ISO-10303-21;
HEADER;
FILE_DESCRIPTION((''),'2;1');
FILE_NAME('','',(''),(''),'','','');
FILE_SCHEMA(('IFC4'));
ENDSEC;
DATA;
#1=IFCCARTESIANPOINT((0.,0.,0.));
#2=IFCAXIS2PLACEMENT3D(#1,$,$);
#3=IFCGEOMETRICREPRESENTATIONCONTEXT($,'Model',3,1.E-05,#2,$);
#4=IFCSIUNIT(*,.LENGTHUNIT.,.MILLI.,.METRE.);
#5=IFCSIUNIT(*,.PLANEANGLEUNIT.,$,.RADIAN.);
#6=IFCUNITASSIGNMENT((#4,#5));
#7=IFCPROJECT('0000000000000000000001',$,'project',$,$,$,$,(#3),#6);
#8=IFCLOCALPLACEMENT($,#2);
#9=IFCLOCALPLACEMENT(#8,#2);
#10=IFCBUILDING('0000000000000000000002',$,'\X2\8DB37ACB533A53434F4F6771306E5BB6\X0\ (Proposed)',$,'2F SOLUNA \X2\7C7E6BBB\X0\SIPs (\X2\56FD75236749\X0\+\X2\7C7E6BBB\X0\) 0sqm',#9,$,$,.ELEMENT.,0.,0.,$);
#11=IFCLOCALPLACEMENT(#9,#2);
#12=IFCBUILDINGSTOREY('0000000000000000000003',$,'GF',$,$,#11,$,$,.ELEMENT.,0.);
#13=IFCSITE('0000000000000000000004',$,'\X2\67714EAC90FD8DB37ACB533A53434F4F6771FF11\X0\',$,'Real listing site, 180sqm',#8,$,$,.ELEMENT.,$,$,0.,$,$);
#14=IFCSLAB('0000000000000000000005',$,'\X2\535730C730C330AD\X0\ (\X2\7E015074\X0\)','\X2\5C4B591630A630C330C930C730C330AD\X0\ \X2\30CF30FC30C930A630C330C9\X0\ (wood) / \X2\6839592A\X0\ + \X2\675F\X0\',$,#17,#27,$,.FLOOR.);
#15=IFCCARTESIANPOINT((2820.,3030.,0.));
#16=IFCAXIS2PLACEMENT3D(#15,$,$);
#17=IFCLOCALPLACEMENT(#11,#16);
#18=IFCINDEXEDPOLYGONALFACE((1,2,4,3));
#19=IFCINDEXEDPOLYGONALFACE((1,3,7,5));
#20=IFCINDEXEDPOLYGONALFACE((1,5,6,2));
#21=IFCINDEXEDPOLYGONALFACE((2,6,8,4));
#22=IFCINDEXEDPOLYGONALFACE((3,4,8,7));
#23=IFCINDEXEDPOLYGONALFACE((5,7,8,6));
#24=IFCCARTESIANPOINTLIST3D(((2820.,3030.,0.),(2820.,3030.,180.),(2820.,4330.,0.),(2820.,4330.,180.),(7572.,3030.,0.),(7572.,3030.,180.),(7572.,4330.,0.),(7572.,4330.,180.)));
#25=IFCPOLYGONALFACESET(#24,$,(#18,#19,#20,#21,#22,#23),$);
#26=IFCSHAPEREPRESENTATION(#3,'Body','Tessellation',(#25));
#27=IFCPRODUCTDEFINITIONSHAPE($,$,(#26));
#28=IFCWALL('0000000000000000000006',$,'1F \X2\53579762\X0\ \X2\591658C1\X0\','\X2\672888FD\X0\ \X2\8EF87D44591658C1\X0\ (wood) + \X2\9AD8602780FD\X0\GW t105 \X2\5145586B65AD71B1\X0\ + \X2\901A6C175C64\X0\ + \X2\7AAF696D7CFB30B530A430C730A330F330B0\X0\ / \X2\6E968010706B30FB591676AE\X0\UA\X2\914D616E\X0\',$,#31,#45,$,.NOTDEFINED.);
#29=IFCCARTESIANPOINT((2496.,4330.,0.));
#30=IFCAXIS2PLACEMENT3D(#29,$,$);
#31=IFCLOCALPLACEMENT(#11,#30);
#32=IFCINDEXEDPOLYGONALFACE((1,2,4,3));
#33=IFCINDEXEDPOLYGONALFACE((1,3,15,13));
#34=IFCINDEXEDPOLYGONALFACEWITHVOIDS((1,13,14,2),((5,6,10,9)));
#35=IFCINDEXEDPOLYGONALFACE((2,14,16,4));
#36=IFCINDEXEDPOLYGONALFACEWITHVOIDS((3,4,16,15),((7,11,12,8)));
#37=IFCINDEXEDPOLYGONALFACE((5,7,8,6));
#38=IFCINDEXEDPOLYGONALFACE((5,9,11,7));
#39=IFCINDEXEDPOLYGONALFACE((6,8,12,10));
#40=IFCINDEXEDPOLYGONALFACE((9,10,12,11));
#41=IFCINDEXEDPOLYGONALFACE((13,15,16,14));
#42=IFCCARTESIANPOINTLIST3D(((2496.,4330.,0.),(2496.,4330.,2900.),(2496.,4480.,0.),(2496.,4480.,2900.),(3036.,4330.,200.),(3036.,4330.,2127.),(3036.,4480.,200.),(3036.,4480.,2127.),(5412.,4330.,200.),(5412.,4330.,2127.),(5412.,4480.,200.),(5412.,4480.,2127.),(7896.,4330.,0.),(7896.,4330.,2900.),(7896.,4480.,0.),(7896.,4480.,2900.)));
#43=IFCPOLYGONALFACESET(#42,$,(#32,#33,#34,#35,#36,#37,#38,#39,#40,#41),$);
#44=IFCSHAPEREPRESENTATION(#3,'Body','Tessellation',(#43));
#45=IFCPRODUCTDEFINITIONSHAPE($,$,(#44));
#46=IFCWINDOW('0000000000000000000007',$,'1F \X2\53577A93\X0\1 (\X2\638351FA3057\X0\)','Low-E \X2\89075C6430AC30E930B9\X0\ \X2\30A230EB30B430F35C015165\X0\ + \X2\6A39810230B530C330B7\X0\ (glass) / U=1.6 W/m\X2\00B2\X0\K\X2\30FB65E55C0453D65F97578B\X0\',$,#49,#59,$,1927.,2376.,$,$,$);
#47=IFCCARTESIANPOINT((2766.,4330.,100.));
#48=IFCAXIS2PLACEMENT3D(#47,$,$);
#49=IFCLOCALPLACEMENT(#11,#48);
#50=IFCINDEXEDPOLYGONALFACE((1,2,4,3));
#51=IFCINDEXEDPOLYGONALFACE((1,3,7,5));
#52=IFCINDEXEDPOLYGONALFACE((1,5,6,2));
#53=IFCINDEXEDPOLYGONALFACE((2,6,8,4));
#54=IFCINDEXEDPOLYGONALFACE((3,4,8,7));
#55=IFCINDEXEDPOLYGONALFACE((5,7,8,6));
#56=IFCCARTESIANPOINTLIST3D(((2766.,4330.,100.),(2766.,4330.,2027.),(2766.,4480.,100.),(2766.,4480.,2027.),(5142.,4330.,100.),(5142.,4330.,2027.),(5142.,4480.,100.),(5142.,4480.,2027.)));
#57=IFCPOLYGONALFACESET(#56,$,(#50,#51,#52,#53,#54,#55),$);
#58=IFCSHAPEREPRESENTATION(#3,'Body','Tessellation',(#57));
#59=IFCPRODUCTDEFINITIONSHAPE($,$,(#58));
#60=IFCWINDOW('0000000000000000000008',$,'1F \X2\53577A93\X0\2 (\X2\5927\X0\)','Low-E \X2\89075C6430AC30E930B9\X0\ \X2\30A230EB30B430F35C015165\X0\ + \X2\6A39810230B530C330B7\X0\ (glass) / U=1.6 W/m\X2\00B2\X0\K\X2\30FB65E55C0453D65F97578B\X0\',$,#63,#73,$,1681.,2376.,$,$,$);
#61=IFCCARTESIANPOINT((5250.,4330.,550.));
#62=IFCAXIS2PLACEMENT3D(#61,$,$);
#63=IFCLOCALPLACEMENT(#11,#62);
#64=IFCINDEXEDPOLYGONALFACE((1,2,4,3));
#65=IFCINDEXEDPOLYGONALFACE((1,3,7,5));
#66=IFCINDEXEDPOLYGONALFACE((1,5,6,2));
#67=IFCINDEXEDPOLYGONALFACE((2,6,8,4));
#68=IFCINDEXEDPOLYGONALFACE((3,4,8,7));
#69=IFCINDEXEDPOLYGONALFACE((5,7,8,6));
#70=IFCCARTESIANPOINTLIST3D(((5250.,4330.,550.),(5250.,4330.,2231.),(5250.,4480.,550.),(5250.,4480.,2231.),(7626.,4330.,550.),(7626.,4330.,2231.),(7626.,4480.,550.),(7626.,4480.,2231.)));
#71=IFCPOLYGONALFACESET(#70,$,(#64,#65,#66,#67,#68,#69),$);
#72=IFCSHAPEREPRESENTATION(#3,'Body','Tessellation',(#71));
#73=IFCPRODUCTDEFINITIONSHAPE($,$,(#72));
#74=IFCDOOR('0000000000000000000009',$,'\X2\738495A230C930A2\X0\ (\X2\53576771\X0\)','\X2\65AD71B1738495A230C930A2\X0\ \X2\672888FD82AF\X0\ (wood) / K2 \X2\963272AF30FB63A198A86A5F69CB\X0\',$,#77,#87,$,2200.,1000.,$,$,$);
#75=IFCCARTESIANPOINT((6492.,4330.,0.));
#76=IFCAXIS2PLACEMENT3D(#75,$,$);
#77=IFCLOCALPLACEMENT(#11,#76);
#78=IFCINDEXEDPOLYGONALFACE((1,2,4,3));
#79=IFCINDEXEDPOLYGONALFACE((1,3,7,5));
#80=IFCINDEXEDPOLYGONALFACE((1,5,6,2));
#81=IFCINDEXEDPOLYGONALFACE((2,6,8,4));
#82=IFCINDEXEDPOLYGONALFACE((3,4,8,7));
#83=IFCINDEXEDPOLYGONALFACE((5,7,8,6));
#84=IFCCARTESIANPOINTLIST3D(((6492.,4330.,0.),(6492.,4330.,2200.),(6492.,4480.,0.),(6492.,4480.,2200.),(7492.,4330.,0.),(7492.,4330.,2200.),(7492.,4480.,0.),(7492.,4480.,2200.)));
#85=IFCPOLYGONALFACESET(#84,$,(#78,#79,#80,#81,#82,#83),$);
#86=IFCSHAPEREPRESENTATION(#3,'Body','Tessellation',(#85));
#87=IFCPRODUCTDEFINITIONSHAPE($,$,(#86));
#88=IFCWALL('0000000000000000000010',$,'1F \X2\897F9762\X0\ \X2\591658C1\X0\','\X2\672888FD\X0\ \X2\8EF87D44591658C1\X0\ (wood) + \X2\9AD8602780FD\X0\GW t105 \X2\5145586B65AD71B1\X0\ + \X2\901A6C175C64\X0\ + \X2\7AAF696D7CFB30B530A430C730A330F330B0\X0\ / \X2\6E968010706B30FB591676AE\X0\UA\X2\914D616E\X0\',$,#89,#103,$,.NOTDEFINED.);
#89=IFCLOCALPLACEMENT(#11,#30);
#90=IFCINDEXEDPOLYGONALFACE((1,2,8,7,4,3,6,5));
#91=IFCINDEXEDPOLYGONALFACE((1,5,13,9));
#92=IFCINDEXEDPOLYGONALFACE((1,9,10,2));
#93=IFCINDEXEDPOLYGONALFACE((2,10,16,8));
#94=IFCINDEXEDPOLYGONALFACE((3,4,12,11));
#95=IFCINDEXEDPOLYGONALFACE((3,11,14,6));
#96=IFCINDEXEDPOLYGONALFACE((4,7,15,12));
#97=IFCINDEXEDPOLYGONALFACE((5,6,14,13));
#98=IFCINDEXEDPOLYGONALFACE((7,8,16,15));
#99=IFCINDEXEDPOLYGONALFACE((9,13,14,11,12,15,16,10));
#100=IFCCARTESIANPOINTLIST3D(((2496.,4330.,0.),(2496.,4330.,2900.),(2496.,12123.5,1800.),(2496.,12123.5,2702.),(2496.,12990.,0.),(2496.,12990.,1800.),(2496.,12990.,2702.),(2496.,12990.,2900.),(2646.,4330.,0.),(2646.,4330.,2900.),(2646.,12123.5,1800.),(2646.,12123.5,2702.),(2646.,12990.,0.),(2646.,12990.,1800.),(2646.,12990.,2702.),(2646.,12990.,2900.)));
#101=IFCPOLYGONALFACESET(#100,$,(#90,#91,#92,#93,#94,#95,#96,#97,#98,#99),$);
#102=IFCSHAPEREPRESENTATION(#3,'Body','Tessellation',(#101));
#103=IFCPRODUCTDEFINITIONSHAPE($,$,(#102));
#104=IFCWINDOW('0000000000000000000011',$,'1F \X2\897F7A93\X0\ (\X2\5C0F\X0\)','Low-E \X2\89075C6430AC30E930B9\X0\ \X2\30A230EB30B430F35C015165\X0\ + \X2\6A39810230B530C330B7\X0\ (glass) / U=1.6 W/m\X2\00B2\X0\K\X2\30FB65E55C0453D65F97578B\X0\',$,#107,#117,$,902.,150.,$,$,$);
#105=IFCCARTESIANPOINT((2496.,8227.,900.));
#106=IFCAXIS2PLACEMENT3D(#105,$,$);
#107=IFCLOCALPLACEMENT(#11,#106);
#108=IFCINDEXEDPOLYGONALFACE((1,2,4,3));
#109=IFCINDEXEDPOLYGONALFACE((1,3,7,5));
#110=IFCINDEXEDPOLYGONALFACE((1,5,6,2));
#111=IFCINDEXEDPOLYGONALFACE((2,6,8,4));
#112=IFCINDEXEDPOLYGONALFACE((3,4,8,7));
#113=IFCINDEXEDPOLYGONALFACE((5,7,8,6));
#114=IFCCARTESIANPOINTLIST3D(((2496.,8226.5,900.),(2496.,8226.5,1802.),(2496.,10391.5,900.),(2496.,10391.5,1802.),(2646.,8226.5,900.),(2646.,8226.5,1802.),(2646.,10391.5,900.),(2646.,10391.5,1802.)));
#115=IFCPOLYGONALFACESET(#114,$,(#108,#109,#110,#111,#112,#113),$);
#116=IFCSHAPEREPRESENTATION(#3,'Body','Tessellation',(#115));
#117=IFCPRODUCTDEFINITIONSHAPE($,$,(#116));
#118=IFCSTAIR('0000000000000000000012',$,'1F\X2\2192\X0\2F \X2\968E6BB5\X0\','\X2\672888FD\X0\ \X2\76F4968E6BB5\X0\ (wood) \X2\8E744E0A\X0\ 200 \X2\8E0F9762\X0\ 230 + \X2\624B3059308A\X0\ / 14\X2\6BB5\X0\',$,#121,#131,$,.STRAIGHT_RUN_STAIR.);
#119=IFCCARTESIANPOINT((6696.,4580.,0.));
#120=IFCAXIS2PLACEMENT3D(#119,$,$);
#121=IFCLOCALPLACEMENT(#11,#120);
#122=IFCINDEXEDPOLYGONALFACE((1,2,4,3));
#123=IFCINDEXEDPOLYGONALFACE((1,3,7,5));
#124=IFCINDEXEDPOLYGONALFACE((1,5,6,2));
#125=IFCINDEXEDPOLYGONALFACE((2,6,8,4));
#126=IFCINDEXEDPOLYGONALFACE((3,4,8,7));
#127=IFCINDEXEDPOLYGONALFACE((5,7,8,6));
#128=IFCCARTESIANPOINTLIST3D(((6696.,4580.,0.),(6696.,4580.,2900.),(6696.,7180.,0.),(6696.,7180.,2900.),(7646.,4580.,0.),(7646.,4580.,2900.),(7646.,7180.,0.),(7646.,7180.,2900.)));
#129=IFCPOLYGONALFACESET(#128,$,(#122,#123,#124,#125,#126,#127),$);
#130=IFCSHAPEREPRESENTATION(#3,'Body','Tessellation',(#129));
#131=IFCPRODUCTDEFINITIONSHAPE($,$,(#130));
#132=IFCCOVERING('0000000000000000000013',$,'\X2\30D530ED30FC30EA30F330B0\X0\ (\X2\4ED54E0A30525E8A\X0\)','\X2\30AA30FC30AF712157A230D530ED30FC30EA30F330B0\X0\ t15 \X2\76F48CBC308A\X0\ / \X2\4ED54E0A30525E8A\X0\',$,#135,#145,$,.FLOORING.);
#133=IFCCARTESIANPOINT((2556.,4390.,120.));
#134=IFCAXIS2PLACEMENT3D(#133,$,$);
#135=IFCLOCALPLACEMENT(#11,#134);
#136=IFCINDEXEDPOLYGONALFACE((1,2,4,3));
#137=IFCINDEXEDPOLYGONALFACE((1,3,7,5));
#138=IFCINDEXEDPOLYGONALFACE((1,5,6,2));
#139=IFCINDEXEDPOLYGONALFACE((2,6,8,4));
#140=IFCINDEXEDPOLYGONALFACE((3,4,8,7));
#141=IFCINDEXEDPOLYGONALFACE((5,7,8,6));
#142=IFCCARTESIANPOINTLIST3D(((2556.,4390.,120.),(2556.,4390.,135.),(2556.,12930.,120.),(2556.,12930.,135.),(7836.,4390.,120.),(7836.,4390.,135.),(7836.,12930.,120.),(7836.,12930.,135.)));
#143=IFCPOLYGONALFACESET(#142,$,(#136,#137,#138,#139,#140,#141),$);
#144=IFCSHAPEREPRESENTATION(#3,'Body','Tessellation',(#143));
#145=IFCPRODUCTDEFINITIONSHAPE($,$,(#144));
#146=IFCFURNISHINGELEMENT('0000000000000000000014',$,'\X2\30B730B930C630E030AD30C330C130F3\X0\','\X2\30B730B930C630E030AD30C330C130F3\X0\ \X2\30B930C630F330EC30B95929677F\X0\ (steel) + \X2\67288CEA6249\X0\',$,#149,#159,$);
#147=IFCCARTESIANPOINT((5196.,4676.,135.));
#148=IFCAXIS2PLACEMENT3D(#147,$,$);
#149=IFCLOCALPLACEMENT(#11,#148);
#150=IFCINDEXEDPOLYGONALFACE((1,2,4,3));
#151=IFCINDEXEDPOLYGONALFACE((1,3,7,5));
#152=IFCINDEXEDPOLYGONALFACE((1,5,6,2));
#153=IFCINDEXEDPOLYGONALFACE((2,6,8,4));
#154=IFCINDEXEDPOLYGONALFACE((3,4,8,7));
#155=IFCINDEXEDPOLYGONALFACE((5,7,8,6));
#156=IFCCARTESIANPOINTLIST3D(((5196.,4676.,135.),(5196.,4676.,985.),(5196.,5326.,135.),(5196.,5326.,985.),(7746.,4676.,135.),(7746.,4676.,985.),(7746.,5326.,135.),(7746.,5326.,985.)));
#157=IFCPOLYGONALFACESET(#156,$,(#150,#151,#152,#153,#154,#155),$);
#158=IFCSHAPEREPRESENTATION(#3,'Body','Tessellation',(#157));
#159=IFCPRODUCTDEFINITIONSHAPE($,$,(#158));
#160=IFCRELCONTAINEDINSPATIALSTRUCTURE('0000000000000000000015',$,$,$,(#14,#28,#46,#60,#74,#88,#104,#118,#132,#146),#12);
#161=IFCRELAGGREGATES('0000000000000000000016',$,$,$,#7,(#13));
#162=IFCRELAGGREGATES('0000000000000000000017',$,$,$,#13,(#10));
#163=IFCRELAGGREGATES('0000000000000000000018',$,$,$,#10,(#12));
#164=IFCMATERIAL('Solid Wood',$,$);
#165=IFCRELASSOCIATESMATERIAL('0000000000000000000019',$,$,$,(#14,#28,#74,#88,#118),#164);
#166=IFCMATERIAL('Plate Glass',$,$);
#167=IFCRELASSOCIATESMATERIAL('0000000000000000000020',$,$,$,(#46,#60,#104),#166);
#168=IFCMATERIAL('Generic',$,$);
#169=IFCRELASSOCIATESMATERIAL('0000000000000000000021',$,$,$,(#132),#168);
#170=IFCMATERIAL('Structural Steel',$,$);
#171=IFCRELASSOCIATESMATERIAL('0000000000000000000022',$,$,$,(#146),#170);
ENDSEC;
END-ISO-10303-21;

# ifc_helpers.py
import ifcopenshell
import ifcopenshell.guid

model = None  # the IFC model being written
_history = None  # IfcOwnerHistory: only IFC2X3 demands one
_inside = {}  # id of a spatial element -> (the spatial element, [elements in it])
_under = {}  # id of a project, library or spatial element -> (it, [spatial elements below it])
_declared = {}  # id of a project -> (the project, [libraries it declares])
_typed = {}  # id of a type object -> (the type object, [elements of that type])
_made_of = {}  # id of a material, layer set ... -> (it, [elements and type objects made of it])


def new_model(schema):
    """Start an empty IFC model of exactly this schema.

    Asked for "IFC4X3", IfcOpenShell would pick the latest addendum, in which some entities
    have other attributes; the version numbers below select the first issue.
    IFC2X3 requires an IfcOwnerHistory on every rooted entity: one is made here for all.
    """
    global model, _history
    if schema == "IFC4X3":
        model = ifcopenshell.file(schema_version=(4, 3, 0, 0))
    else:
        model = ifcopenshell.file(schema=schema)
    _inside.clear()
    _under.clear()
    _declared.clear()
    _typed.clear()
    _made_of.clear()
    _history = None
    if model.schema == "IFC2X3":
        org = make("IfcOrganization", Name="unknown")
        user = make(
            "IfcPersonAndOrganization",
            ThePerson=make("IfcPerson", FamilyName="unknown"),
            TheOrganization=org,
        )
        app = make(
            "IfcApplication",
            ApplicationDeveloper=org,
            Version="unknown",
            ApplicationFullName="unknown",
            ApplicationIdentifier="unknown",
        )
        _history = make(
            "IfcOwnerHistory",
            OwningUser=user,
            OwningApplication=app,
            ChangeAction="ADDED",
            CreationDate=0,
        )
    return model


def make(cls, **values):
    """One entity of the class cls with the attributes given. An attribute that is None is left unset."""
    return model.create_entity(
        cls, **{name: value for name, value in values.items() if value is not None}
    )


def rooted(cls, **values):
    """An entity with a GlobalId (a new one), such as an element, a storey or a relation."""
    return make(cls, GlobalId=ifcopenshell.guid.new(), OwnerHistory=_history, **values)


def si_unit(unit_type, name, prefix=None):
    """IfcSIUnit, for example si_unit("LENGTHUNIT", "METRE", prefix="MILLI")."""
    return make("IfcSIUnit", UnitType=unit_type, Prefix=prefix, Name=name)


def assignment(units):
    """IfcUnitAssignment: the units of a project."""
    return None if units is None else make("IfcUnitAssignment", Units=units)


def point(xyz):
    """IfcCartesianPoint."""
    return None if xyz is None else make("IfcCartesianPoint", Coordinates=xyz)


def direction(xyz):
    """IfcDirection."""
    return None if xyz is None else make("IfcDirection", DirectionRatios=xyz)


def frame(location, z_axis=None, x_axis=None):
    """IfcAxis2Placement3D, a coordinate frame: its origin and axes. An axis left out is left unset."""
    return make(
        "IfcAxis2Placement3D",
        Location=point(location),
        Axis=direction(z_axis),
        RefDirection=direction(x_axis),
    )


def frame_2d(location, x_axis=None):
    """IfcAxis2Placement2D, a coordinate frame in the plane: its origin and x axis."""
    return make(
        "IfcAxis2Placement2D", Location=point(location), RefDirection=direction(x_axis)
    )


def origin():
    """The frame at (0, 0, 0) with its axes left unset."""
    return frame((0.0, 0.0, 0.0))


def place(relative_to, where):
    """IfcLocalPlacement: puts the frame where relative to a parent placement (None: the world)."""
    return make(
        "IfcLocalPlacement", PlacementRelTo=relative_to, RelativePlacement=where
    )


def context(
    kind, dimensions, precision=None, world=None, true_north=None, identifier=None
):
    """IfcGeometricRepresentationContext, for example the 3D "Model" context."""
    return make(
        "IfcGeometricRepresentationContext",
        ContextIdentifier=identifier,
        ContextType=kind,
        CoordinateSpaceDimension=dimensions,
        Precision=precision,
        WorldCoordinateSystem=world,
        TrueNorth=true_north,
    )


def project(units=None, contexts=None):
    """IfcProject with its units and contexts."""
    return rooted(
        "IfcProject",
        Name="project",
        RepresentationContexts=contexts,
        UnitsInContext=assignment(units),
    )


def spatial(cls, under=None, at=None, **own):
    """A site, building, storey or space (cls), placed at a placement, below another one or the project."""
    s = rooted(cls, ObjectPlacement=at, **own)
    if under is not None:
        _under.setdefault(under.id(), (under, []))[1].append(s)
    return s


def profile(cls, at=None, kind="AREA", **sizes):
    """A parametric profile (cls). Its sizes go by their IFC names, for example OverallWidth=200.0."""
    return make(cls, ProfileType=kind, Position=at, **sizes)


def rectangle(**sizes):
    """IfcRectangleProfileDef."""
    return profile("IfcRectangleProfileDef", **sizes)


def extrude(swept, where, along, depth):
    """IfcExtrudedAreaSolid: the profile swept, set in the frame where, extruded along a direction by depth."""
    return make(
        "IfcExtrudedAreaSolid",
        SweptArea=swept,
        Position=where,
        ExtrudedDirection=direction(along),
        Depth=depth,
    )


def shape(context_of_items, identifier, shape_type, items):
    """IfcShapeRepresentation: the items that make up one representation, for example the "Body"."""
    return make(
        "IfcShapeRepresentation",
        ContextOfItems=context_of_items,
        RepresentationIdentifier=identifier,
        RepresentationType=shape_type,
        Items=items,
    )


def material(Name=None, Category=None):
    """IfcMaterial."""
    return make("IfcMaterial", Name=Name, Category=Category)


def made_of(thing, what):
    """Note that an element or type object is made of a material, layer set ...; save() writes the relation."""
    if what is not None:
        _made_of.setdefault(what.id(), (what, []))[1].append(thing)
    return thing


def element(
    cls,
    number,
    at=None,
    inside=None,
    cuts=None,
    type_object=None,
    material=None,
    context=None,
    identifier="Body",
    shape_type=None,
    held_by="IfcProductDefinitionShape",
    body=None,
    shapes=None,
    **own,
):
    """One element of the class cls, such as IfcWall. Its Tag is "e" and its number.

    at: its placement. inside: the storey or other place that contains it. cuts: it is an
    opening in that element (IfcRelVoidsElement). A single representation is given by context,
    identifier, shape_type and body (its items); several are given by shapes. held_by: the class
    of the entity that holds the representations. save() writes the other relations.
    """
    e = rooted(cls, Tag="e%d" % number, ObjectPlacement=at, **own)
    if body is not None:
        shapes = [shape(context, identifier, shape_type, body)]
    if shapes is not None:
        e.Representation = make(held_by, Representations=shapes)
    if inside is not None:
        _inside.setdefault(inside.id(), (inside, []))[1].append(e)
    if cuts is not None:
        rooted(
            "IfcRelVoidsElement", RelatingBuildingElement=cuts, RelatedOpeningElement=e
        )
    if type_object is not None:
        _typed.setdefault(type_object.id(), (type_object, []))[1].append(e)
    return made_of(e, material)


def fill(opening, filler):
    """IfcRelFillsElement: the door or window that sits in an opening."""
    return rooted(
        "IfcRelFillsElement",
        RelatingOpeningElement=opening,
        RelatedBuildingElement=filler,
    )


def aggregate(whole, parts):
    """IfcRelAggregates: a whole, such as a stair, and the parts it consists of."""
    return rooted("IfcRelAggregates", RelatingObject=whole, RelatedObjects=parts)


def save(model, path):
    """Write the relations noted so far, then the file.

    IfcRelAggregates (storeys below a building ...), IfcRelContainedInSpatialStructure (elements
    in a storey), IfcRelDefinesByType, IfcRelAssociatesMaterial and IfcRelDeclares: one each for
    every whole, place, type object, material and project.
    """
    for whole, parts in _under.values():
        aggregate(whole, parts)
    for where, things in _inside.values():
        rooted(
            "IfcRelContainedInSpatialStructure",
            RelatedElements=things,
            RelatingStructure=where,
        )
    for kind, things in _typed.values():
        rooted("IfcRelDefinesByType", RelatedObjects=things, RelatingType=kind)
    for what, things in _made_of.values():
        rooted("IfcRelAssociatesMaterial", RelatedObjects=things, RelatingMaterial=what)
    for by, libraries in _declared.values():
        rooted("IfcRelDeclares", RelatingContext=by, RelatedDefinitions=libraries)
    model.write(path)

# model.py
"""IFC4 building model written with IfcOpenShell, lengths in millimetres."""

from ifc_helpers import new_model, si_unit, frame, frame_2d, origin, place, context, project, spatial, rectangle, extrude, material, element, fill, save


model = new_model("IFC4")

# Units and contexts
model_context = context("Model", 3, precision=1e-05, world=origin())
ifc_project = project(units=[si_unit("LENGTHUNIT", "METRE", prefix="MILLI"), si_unit("PLANEANGLEUNIT", "RADIAN")], contexts=[model_context])

# Site, building, storey
site_placement = place(None, origin())
site = spatial("IfcSite", under=ifc_project, at=site_placement, Name="東京都足立区千住東１", ObjectType="Real listing site, 180sqm", CompositionType="ELEMENT", RefElevation=0.0)
building_placement = place(site_placement, origin())
building = spatial("IfcBuilding", under=site, at=building_placement, Name="足立区千住東の家 (Proposed)", ObjectType="2F SOLUNA 籾殻SIPs (国産杉+籾殻) 0sqm", CompositionType="ELEMENT", ElevationOfRefHeight=0.0, ElevationOfTerrain=0.0)
storey_placement = place(building_placement, origin())
storey = spatial("IfcBuildingStorey", under=building, at=storey_placement, Name="GF", CompositionType="ELEMENT", Elevation=0.0)

# Slab
ifc_material_1 = material(Name="Solid Wood")
slab_1_placement = place(storey_placement, frame((2820.0, 3030.0, 0.0)))
element("IfcSlab", 1, at=slab_1_placement, inside=storey, material=ifc_material_1, Name="南デッキ (縁側)", Description="屋外ウッドデッキ ハードウッド (wood) / 根太 + 束", PredefinedType="FLOOR", context=model_context, shape_type="SweptSolid", body=[
    extrude(rectangle(XDim=4752.0, YDim=1300.0, at=frame_2d((2376.0, 650.0))), frame((2820.0, 3030.0, 0.0)), (0.0, 0.0, 1.0), 180.0),
])

# Wall, openings, windows, door
wall_1_placement = place(storey_placement, frame((2496.0, 4330.0, 0.0)))
wall_1 = element("IfcWall", 2, at=wall_1_placement, inside=storey, material=ifc_material_1, Name="1F 南面 外壁", Description="木製 軸組外壁 (wood) + 高性能GW t105 充填断熱 + 通気層 + 窯業系サイディング / 準耐火・外皮UA配慮", PredefinedType="NOTDEFINED", context=model_context, shape_type="SweptSolid", body=[
    extrude(rectangle(XDim=5400.0, YDim=150.0, at=frame_2d((2700.0, 75.0))), frame((2496.0, 4330.0, 0.0)), (0.0, 0.0, 1.0), 2900.0),
])
opening_1_placement = place(storey_placement, frame((2766.0, 4330.0, 100.0)))
opening_1 = element("IfcOpeningElement", 3, at=opening_1_placement, cuts=wall_1, PredefinedType="NOTDEFINED", context=model_context, shape_type="SweptSolid", body=[
    extrude(rectangle(XDim=2376.0, YDim=150.0, at=frame_2d((1188.0, 75.0))), frame((2766.0, 4330.0, 100.0)), (0.0, 0.0, 1.0), 1927.0),
])
opening_2_placement = place(storey_placement, frame((5250.0, 4330.0, 550.0)))
opening_2 = element("IfcOpeningElement", 4, at=opening_2_placement, cuts=wall_1, PredefinedType="NOTDEFINED", context=model_context, shape_type="SweptSolid", body=[
    extrude(rectangle(XDim=2376.0, YDim=150.0, at=frame_2d((1188.0, 75.0))), frame((5250.0, 4330.0, 550.0)), (0.0, 0.0, 1.0), 1681.0),
])
opening_3_placement = place(storey_placement, frame((6492.0, 4330.0, 0.0)))
opening_3 = element("IfcOpeningElement", 5, at=opening_3_placement, cuts=wall_1, PredefinedType="NOTDEFINED", context=model_context, shape_type="SweptSolid", body=[
    extrude(rectangle(XDim=1000.0, YDim=150.0, at=frame_2d((500.0, 75.0))), frame((6492.0, 4330.0, 0.0)), (0.0, 0.0, 1.0), 2200.0),
])
ifc_material_2 = material(Name="Plate Glass")
window_1_placement = place(storey_placement, frame((2766.0, 4330.0, 100.0)))
window_1 = element("IfcWindow", 6, at=window_1_placement, inside=storey, material=ifc_material_2, Name="1F 南窓1 (掃出し)", Description="Low-E 複層ガラス アルゴン封入 + 樹脂サッシ (glass) / U=1.6 W/m²K・日射取得型", OverallHeight=1927.0, OverallWidth=2376.0, context=model_context, shape_type="SweptSolid", body=[
    extrude(rectangle(XDim=2376.0, YDim=150.0, at=frame_2d((1188.0, 75.0))), frame((2766.0, 4330.0, 100.0)), (0.0, 0.0, 1.0), 1927.0),
])
fill(opening_1, window_1)
window_2_placement = place(storey_placement, frame((5250.0, 4330.0, 550.0)))
window_2 = element("IfcWindow", 7, at=window_2_placement, inside=storey, material=ifc_material_2, Name="1F 南窓2 (大)", Description="Low-E 複層ガラス アルゴン封入 + 樹脂サッシ (glass) / U=1.6 W/m²K・日射取得型", OverallHeight=1681.0, OverallWidth=2376.0, context=model_context, shape_type="SweptSolid", body=[
    extrude(rectangle(XDim=2376.0, YDim=150.0, at=frame_2d((1188.0, 75.0))), frame((5250.0, 4330.0, 550.0)), (0.0, 0.0, 1.0), 1681.0),
])
fill(opening_2, window_2)
door_placement = place(storey_placement, frame((6492.0, 4330.0, 0.0)))
door = element("IfcDoor", 8, at=door_placement, inside=storey, material=ifc_material_1, Name="玄関ドア (南東)", Description="断熱玄関ドア 木製芯 (wood) / K2 防犯・採風機構", OverallHeight=2200.0, OverallWidth=1000.0, context=model_context, shape_type="SweptSolid", body=[
    extrude(rectangle(XDim=1000.0, YDim=150.0, at=frame_2d((500.0, 75.0))), frame((6492.0, 4330.0, 0.0)), (0.0, 0.0, 1.0), 2200.0),
])
fill(opening_3, door)

# Wall, opening, window
wall_2_placement = place(storey_placement, frame((2496.0, 4330.0, 0.0)))
wall_2 = element("IfcWall", 9, at=wall_2_placement, inside=storey, material=ifc_material_1, Name="1F 西面 外壁", Description="木製 軸組外壁 (wood) + 高性能GW t105 充填断熱 + 通気層 + 窯業系サイディング / 準耐火・外皮UA配慮", PredefinedType="NOTDEFINED", context=model_context, shape_type="SweptSolid", body=[
    extrude(rectangle(XDim=150.0, YDim=8660.0, at=frame_2d((75.0, 4330.0))), frame((2496.0, 4330.0, 0.0)), (0.0, 0.0, 1.0), 2900.0),
])
opening_4_placement = place(storey_placement, frame((2496.0, 8227.0, 900.0)))
opening_4 = element("IfcOpeningElement", 10, at=opening_4_placement, cuts=wall_2, PredefinedType="NOTDEFINED", context=model_context, shape_type="SweptSolid", body=[
    extrude(rectangle(XDim=150.0, YDim=2165.0, at=frame_2d((75.0, 1082.0))), frame((2496.0, 8227.0, 900.0)), (0.0, 0.0, 1.0), 902.0),
])
window_3_placement = place(storey_placement, frame((2496.0, 8227.0, 900.0)))
window_3 = element("IfcWindow", 11, at=window_3_placement, inside=storey, material=ifc_material_2, Name="1F 西窓 (小)", Description="Low-E 複層ガラス アルゴン封入 + 樹脂サッシ (glass) / U=1.6 W/m²K・日射取得型", OverallHeight=902.0, OverallWidth=150.0, context=model_context, shape_type="SweptSolid", body=[
    extrude(rectangle(XDim=150.0, YDim=2165.0, at=frame_2d((75.0, 1082.0))), frame((2496.0, 8227.0, 900.0)), (0.0, 0.0, 1.0), 902.0),
])
fill(opening_4, window_3)

# Stair
stair_placement = place(storey_placement, frame((6696.0, 4580.0, 0.0)))
element("IfcStair", 12, at=stair_placement, inside=storey, material=ifc_material_1, Name="1F→2F 階段", Description="木製 直階段 (wood) 蹴上 200 踏面 230 + 手すり / 14段", PredefinedType="STRAIGHT_RUN_STAIR", context=model_context, shape_type="SweptSolid", body=[
    extrude(rectangle(XDim=950.0, YDim=2600.0, at=frame_2d((475.0, 1300.0))), frame((6696.0, 4580.0, 0.0)), (0.0, 0.0, 1.0), 2900.0),
])

# Covering
ifc_material_3 = material(Name="Generic")
covering_placement = place(storey_placement, frame((2556.0, 4390.0, 120.0)))
element("IfcCovering", 13, at=covering_placement, inside=storey, material=ifc_material_3, Name="フローリング (仕上げ床)", Description="オーク無垢フローリング t15 直貼り / 仕上げ床", PredefinedType="FLOORING", context=model_context, shape_type="SweptSolid", body=[
    extrude(rectangle(XDim=5280.0, YDim=8540.0, at=frame_2d((2640.0, 4270.0))), frame((2556.0, 4390.0, 120.0)), (0.0, 0.0, 1.0), 15.0),
])

# Furnishing element
ifc_material_4 = material(Name="Structural Steel")
furnishing_placement = place(storey_placement, frame((5196.0, 4676.0, 135.0)))
element("IfcFurnishingElement", 14, at=furnishing_placement, inside=storey, material=ifc_material_4, Name="システムキッチン", Description="システムキッチン ステンレス天板 (steel) + 木質扉", context=model_context, shape_type="SweptSolid", body=[
    extrude(rectangle(XDim=2550.0, YDim=650.0, at=frame_2d((1275.0, 325.0))), frame((5196.0, 4676.0, 135.0)), (0.0, 0.0, 1.0), 850.0),
])

save(model, "model.ifc")
